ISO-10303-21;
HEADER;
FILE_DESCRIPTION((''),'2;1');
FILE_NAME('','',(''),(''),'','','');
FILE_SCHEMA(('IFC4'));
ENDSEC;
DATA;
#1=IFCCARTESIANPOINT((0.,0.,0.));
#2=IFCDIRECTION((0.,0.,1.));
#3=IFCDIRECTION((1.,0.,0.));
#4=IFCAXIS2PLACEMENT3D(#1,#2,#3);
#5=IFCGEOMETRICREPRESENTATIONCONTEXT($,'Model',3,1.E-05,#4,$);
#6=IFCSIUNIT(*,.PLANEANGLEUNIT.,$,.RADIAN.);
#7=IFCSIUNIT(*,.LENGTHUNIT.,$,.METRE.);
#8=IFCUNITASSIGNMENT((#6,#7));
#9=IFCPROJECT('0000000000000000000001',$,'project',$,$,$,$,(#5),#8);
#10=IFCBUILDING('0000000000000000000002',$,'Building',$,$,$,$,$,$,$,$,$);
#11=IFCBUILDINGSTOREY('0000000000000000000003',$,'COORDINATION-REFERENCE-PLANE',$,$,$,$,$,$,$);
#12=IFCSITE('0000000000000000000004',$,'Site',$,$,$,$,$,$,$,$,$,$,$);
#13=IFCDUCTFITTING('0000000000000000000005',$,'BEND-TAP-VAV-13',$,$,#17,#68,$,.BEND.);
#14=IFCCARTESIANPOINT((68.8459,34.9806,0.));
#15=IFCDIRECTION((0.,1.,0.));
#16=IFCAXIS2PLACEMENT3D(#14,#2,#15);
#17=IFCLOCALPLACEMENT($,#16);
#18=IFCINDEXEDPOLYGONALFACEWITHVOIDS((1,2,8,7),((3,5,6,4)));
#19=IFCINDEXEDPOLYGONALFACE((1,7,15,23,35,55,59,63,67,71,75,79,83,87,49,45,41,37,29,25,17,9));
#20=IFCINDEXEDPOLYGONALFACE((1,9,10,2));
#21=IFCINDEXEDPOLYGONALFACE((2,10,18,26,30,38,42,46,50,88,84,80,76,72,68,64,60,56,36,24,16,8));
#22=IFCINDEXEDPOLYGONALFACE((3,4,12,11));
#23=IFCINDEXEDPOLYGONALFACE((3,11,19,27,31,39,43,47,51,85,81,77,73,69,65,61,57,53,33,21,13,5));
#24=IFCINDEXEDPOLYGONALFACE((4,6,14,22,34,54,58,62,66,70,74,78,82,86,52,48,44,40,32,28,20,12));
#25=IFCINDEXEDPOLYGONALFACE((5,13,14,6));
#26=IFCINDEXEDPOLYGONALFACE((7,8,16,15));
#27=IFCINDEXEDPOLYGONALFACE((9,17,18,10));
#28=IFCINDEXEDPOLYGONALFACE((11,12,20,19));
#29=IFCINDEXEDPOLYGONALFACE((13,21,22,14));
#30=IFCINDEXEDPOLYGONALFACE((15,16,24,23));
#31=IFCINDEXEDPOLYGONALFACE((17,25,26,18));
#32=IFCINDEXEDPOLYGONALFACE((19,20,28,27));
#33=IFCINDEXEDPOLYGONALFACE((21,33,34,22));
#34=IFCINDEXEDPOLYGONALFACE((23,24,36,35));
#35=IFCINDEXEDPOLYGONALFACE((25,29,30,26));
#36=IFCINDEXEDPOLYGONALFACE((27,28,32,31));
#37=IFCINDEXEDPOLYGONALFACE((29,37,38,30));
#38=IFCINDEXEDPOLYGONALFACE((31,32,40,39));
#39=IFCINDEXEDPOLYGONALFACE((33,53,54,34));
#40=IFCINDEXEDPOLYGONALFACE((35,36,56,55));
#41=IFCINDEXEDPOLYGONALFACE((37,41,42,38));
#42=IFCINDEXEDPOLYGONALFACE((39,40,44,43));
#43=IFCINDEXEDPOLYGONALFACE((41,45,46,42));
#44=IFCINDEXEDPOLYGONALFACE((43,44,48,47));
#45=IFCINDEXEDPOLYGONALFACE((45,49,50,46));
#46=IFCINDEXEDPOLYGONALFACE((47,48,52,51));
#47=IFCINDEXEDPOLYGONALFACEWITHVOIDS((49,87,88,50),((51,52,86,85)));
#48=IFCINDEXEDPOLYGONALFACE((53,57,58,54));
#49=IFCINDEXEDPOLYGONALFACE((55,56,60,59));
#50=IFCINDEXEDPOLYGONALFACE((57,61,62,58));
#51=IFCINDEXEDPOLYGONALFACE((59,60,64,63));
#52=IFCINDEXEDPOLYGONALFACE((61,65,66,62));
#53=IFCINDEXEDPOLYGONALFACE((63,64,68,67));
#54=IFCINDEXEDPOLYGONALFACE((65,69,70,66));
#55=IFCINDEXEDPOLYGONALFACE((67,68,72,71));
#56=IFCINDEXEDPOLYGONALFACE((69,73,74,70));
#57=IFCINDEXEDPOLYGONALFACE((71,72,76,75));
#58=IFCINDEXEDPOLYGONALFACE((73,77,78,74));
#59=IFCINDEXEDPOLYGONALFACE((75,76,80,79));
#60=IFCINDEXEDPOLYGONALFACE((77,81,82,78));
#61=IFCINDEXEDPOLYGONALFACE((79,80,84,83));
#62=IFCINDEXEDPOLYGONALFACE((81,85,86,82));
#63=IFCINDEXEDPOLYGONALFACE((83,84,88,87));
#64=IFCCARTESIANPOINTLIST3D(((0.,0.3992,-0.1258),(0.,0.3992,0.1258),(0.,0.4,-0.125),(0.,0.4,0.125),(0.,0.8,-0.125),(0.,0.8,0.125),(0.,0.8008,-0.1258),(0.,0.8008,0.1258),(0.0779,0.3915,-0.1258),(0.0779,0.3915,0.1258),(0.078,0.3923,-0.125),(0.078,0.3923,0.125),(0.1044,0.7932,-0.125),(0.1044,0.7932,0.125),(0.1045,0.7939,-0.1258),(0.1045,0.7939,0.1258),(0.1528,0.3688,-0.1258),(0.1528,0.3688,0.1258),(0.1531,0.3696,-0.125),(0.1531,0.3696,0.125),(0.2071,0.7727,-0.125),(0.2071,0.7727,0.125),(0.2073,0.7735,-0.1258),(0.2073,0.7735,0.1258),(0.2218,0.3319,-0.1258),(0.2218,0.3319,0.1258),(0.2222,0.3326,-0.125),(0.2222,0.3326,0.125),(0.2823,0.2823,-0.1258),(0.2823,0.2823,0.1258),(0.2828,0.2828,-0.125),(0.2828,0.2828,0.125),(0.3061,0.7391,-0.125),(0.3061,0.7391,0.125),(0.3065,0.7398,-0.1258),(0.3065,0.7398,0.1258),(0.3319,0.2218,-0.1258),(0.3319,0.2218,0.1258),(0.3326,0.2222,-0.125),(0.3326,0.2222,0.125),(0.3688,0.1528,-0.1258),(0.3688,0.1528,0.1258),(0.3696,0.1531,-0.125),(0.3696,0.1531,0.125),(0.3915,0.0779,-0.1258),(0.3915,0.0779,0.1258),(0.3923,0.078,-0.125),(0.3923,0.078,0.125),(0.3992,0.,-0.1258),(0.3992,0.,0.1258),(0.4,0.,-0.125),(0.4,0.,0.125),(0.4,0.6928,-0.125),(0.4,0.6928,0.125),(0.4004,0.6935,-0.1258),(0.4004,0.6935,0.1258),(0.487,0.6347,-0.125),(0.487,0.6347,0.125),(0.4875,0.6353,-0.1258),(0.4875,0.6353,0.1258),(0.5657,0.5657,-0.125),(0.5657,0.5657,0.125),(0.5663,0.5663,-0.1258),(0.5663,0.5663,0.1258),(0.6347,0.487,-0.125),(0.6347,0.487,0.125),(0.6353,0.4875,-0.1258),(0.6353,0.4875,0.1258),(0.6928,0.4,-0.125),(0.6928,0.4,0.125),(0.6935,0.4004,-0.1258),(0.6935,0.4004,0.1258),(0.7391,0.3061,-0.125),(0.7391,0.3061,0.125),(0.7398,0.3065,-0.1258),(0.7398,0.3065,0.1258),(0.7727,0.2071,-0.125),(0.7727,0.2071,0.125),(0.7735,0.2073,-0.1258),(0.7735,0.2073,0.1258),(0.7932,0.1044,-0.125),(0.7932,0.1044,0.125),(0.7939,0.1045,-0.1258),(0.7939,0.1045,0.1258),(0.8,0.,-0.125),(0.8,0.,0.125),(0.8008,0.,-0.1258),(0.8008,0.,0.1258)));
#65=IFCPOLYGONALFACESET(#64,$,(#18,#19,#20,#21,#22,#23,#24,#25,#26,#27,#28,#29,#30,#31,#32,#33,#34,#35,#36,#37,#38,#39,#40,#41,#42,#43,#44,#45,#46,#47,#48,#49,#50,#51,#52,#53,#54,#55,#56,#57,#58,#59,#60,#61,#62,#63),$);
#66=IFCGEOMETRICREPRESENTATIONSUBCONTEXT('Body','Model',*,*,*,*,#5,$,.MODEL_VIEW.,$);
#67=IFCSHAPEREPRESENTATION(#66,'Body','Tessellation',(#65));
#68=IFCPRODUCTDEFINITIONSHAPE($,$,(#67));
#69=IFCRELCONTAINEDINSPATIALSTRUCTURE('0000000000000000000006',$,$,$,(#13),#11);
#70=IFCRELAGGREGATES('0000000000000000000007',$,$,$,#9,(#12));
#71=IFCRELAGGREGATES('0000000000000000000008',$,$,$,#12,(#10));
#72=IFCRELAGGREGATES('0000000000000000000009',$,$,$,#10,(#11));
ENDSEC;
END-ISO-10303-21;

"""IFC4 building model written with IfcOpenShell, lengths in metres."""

from ifc_helpers import new_model, entity, si_unit, frame, origin_with_axes, place, context, subcontext, project, spatial, element, save


model = new_model("IFC4")

# Units and contexts
model_context = context("Model", 3, precision=1e-05, world=origin_with_axes())
body_context = subcontext(model_context, "Body", "Model", "MODEL_VIEW")
ifc_project = project(units=[si_unit("PLANEANGLEUNIT", "RADIAN"), si_unit("LENGTHUNIT", "METRE")], contexts=[model_context])

# Site, building, storey
site = spatial("IfcSite", under=ifc_project, Name="Site")
building = spatial("IfcBuilding", under=site, Name="Building")
storey = spatial("IfcBuildingStorey", under=building, Name="COORDINATION-REFERENCE-PLANE")

# Duct fitting
duct_fitting_1_placement = place(None, frame((68.8459, 34.9806, 0.0), z_axis=(0.0, 0.0, 1.0), x_axis=(0.0, 1.0, 0.0)))
cartesian_point_1 = entity("IfcCartesianPoint", [0.0, 0.0, 0.0])
element("IfcDuctFitting", 1, at=duct_fitting_1_placement, inside=storey, Name="BEND-TAP-VAV-13", PredefinedType="BEND", context=body_context, shape_type="SweptSolid", body=[
    entity("IfcRevolvedAreaSolid", entity("IfcRectangleHollowProfileDef", "AREA", None, entity("IfcAxis2Placement2D", entity("IfcCartesianPoint", [0.6, 0.0])), 0.4016, 0.2516, 0.0008), entity("IfcAxis2Placement3D", cartesian_point_1, entity("IfcDirection", [0.0, -1.0, 0.0]), entity("IfcDirection", [1.0, 0.0, 0.0])), entity("IfcAxis1Placement", cartesian_point_1, entity("IfcDirection", [0.0, 1.0, 0.0])), 1.570796),
])

save(model, "model.ifc")
